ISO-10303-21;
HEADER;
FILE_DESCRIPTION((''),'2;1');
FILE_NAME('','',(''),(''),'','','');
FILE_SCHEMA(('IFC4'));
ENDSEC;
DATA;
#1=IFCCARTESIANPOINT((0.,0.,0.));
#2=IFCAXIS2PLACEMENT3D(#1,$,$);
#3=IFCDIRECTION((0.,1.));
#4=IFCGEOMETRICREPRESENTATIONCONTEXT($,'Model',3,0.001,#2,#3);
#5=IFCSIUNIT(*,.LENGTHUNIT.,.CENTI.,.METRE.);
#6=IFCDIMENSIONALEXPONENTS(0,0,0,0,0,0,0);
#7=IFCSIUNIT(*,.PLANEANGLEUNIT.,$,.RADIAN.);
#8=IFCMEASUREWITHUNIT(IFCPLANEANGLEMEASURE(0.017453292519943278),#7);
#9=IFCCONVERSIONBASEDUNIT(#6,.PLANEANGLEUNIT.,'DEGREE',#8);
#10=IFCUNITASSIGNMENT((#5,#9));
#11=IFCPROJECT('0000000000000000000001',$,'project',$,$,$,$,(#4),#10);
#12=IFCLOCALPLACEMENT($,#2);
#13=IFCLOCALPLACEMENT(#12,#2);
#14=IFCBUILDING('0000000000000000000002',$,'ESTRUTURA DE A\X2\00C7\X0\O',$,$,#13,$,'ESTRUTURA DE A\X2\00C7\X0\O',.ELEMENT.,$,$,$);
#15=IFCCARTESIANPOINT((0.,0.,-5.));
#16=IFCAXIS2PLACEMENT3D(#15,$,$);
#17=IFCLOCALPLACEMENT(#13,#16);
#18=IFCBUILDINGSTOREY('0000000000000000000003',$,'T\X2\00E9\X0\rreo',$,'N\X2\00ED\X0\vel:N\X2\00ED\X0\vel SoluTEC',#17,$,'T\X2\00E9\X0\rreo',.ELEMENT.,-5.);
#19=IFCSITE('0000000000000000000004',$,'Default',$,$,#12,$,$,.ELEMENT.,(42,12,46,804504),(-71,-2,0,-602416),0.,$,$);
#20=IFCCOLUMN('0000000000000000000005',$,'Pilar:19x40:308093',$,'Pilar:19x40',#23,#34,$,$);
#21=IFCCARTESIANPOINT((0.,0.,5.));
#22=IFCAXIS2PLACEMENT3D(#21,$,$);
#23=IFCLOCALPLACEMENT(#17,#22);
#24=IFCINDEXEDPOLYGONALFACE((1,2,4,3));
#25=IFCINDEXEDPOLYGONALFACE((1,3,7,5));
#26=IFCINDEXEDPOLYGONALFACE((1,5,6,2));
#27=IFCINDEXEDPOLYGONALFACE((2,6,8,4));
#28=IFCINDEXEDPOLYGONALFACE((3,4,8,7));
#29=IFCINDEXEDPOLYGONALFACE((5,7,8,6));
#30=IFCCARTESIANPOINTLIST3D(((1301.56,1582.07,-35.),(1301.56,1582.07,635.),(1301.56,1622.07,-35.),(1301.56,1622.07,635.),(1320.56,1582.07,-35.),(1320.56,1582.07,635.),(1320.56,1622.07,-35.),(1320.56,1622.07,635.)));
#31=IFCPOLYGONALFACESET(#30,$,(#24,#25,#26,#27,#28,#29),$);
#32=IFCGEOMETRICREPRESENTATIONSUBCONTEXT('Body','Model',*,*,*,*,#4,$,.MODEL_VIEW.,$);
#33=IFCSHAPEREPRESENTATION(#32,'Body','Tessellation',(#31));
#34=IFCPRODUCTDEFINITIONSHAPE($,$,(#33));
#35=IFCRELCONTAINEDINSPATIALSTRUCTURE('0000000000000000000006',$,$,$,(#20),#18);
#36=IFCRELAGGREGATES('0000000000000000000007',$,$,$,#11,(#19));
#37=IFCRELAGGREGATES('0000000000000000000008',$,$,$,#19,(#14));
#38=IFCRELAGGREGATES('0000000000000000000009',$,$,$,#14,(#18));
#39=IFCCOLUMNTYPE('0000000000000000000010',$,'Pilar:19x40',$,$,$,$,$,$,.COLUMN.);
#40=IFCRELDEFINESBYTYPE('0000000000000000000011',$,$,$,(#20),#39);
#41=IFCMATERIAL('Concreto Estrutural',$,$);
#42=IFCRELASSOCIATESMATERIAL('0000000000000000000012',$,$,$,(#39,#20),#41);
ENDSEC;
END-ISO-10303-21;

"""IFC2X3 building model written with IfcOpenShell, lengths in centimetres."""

from ifc_helpers import new_model, entity, si_unit, converted_unit, direction, frame, origin, origin_2d_with_axis, place, context, subcontext, project, spatial, rectangle, extrude, source, transform, mapped, material, type_object, type_shapes, element, save


model = new_model("IFC2X3")

# Units and contexts
model_context = context("Model", 3, precision=0.001, world=origin(), true_north=direction((0.0, 1.0)))
body_context = subcontext(model_context, "Body", "Model", "MODEL_VIEW")
ifc_project = project(units=[si_unit("LENGTHUNIT", "METRE", prefix="CENTI"), converted_unit("PLANEANGLEUNIT", "DEGREE", entity("IfcPlaneAngleMeasure", 0.017453292519943278), si_unit("PLANEANGLEUNIT", "RADIAN"), dimensions=[0, 0, 0, 0, 0, 0, 0])], contexts=[model_context])

# Site, building, storey
site_placement = place(None, origin())
site = spatial("IfcSite", under=ifc_project, at=site_placement, Name="Default", CompositionType="ELEMENT", RefLatitude=(42, 12, 46, 804504), RefLongitude=(-71, -2, 0, -602416), RefElevation=0.0)
building_placement = place(site_placement, origin())
building = spatial("IfcBuilding", under=site, at=building_placement, Name="ESTRUTURA DE AÇO", LongName="ESTRUTURA DE AÇO", CompositionType="ELEMENT")
storey_placement = place(building_placement, frame((0.0, 0.0, -5.0)))
storey = spatial("IfcBuildingStorey", under=building, at=storey_placement, Name="Térreo", ObjectType="Nível:Nível SoluTEC", LongName="Térreo", CompositionType="ELEMENT", Elevation=-5.0)

# Column
ifc_material = material(Name="Concreto Estrutural")
column_type = type_object("IfcColumnType", Name="Pilar:19x40", PredefinedType="COLUMN", material=ifc_material)
shared_shape = source(origin(), body_context, "Body", "SweptSolid", [
    extrude(rectangle(XDim=19.0, YDim=40.0, at=origin_2d_with_axis()), frame((1311.06, 1602.07, -35.0), z_axis=(0.0, 0.0, 1.0), x_axis=(-1.0, 0.0, 0.0)), (0.0, 0.0, 1.0), 670.0),
])
type_shapes(column_type, [shared_shape])
column_placement = place(storey_placement, frame((0.0, 0.0, 5.0)))
element("IfcColumn", 1, at=column_placement, inside=storey, type_object=column_type, material=ifc_material, Name="Pilar:19x40:308093", ObjectType="Pilar:19x40", context=body_context, shape_type="MappedRepresentation", body=[
    mapped(shared_shape, transform((0.0, 0.0, 0.0), scale=1.0)),
])

save(model, "model.ifc")
